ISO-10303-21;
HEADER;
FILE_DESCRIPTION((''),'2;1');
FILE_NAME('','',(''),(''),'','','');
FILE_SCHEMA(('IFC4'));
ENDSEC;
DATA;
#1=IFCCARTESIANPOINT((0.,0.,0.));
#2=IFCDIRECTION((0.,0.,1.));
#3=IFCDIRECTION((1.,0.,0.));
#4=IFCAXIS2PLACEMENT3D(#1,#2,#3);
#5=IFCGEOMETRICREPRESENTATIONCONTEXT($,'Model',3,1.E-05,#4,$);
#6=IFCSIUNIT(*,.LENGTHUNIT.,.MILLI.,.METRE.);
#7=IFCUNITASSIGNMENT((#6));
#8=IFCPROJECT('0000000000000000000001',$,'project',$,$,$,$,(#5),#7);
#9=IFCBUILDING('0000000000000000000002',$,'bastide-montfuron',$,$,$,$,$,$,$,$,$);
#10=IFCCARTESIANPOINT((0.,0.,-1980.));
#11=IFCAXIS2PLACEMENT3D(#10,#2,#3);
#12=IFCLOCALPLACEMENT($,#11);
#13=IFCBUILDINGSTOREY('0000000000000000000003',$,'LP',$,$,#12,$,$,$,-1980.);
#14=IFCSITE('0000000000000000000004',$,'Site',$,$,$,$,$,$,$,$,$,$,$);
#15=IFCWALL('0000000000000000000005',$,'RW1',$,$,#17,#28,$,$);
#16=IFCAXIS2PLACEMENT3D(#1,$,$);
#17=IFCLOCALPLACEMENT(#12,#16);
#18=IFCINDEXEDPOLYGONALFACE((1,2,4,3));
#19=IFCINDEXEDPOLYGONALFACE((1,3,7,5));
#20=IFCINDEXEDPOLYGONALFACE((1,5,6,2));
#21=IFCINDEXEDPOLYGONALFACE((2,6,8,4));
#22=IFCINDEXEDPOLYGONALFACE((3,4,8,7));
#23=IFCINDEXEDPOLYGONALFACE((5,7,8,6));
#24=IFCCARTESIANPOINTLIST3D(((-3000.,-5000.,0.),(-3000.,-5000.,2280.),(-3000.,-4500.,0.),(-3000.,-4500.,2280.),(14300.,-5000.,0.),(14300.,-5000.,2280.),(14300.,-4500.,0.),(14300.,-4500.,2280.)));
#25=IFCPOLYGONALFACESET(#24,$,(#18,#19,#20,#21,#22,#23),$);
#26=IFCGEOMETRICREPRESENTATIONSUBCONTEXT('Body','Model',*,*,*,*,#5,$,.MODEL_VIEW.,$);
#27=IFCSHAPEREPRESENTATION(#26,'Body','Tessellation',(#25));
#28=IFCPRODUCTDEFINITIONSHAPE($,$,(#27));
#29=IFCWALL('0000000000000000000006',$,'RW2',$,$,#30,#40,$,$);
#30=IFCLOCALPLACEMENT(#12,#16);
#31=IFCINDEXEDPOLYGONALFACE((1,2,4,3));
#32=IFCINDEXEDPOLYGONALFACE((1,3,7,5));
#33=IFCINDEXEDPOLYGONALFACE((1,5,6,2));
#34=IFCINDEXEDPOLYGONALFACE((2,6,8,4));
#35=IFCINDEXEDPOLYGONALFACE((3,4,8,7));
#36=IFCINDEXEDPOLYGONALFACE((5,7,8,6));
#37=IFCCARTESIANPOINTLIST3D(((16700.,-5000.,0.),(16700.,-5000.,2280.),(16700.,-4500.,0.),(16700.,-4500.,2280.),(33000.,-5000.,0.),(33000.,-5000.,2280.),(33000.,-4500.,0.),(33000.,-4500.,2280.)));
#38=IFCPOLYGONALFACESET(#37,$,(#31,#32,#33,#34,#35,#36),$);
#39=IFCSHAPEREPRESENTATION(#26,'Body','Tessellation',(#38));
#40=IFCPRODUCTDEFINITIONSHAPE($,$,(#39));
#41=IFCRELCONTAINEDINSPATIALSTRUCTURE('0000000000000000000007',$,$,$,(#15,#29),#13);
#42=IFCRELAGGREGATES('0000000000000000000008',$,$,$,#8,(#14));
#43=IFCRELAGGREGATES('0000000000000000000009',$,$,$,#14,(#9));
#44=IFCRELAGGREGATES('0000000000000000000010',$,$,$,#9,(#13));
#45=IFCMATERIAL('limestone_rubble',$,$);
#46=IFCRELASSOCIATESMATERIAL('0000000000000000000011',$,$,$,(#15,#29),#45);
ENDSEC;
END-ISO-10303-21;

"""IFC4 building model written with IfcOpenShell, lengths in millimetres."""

from ifc_helpers import new_model, si_unit, frame, origin_with_axes, place, context, subcontext, project, spatial, indexed_curve, outline, extrude, material, element, save


model = new_model("IFC4")

# Units and contexts
model_context = context("Model", 3, precision=1e-05, world=origin_with_axes())
body_context = subcontext(model_context, "Body", "Model", "MODEL_VIEW")
ifc_project = project(units=[si_unit("LENGTHUNIT", "METRE", prefix="MILLI")], contexts=[model_context])

# Site, building, storey
site = spatial("IfcSite", under=ifc_project, Name="Site")
building = spatial("IfcBuilding", under=site, Name="bastide-montfuron")
storey_placement = place(None, frame((0.0, 0.0, -1980.0), z_axis=(0.0, 0.0, 1.0), x_axis=(1.0, 0.0, 0.0)))
storey = spatial("IfcBuildingStorey", under=building, at=storey_placement, Name="LP", Elevation=-1980.0)

# Walls
ifc_material = material(Name="limestone_rubble")
wall_1_placement = place(storey_placement, frame((14300.0, -4500.0, 0.0), z_axis=(0.0, 0.0, 1.0), x_axis=(-1.0, 0.0, 0.0)))
element("IfcWall", 1, at=wall_1_placement, inside=storey, material=ifc_material, Name="RW1", context=body_context, shape_type="SweptSolid", body=[
    extrude(outline(indexed_curve([(0.0, 0.0), (0.0, 500.0), (17300.0, 500.0), (17300.0, 0.0), (0.0, 0.0)], self_intersect=False)), origin_with_axes(), (0.0, 0.0, 1.0), 2280.0),
])
wall_2_placement = place(storey_placement, frame((33000.0, -4500.0, 0.0), z_axis=(0.0, 0.0, 1.0), x_axis=(-1.0, 0.0, 0.0)))
element("IfcWall", 2, at=wall_2_placement, inside=storey, material=ifc_material, Name="RW2", context=body_context, shape_type="SweptSolid", body=[
    extrude(outline(indexed_curve([(0.0, 0.0), (0.0, 500.0), (16300.0, 500.0), (16300.0, 0.0), (0.0, 0.0)], self_intersect=False)), origin_with_axes(), (0.0, 0.0, 1.0), 2280.0),
])

save(model, "model.ifc")
